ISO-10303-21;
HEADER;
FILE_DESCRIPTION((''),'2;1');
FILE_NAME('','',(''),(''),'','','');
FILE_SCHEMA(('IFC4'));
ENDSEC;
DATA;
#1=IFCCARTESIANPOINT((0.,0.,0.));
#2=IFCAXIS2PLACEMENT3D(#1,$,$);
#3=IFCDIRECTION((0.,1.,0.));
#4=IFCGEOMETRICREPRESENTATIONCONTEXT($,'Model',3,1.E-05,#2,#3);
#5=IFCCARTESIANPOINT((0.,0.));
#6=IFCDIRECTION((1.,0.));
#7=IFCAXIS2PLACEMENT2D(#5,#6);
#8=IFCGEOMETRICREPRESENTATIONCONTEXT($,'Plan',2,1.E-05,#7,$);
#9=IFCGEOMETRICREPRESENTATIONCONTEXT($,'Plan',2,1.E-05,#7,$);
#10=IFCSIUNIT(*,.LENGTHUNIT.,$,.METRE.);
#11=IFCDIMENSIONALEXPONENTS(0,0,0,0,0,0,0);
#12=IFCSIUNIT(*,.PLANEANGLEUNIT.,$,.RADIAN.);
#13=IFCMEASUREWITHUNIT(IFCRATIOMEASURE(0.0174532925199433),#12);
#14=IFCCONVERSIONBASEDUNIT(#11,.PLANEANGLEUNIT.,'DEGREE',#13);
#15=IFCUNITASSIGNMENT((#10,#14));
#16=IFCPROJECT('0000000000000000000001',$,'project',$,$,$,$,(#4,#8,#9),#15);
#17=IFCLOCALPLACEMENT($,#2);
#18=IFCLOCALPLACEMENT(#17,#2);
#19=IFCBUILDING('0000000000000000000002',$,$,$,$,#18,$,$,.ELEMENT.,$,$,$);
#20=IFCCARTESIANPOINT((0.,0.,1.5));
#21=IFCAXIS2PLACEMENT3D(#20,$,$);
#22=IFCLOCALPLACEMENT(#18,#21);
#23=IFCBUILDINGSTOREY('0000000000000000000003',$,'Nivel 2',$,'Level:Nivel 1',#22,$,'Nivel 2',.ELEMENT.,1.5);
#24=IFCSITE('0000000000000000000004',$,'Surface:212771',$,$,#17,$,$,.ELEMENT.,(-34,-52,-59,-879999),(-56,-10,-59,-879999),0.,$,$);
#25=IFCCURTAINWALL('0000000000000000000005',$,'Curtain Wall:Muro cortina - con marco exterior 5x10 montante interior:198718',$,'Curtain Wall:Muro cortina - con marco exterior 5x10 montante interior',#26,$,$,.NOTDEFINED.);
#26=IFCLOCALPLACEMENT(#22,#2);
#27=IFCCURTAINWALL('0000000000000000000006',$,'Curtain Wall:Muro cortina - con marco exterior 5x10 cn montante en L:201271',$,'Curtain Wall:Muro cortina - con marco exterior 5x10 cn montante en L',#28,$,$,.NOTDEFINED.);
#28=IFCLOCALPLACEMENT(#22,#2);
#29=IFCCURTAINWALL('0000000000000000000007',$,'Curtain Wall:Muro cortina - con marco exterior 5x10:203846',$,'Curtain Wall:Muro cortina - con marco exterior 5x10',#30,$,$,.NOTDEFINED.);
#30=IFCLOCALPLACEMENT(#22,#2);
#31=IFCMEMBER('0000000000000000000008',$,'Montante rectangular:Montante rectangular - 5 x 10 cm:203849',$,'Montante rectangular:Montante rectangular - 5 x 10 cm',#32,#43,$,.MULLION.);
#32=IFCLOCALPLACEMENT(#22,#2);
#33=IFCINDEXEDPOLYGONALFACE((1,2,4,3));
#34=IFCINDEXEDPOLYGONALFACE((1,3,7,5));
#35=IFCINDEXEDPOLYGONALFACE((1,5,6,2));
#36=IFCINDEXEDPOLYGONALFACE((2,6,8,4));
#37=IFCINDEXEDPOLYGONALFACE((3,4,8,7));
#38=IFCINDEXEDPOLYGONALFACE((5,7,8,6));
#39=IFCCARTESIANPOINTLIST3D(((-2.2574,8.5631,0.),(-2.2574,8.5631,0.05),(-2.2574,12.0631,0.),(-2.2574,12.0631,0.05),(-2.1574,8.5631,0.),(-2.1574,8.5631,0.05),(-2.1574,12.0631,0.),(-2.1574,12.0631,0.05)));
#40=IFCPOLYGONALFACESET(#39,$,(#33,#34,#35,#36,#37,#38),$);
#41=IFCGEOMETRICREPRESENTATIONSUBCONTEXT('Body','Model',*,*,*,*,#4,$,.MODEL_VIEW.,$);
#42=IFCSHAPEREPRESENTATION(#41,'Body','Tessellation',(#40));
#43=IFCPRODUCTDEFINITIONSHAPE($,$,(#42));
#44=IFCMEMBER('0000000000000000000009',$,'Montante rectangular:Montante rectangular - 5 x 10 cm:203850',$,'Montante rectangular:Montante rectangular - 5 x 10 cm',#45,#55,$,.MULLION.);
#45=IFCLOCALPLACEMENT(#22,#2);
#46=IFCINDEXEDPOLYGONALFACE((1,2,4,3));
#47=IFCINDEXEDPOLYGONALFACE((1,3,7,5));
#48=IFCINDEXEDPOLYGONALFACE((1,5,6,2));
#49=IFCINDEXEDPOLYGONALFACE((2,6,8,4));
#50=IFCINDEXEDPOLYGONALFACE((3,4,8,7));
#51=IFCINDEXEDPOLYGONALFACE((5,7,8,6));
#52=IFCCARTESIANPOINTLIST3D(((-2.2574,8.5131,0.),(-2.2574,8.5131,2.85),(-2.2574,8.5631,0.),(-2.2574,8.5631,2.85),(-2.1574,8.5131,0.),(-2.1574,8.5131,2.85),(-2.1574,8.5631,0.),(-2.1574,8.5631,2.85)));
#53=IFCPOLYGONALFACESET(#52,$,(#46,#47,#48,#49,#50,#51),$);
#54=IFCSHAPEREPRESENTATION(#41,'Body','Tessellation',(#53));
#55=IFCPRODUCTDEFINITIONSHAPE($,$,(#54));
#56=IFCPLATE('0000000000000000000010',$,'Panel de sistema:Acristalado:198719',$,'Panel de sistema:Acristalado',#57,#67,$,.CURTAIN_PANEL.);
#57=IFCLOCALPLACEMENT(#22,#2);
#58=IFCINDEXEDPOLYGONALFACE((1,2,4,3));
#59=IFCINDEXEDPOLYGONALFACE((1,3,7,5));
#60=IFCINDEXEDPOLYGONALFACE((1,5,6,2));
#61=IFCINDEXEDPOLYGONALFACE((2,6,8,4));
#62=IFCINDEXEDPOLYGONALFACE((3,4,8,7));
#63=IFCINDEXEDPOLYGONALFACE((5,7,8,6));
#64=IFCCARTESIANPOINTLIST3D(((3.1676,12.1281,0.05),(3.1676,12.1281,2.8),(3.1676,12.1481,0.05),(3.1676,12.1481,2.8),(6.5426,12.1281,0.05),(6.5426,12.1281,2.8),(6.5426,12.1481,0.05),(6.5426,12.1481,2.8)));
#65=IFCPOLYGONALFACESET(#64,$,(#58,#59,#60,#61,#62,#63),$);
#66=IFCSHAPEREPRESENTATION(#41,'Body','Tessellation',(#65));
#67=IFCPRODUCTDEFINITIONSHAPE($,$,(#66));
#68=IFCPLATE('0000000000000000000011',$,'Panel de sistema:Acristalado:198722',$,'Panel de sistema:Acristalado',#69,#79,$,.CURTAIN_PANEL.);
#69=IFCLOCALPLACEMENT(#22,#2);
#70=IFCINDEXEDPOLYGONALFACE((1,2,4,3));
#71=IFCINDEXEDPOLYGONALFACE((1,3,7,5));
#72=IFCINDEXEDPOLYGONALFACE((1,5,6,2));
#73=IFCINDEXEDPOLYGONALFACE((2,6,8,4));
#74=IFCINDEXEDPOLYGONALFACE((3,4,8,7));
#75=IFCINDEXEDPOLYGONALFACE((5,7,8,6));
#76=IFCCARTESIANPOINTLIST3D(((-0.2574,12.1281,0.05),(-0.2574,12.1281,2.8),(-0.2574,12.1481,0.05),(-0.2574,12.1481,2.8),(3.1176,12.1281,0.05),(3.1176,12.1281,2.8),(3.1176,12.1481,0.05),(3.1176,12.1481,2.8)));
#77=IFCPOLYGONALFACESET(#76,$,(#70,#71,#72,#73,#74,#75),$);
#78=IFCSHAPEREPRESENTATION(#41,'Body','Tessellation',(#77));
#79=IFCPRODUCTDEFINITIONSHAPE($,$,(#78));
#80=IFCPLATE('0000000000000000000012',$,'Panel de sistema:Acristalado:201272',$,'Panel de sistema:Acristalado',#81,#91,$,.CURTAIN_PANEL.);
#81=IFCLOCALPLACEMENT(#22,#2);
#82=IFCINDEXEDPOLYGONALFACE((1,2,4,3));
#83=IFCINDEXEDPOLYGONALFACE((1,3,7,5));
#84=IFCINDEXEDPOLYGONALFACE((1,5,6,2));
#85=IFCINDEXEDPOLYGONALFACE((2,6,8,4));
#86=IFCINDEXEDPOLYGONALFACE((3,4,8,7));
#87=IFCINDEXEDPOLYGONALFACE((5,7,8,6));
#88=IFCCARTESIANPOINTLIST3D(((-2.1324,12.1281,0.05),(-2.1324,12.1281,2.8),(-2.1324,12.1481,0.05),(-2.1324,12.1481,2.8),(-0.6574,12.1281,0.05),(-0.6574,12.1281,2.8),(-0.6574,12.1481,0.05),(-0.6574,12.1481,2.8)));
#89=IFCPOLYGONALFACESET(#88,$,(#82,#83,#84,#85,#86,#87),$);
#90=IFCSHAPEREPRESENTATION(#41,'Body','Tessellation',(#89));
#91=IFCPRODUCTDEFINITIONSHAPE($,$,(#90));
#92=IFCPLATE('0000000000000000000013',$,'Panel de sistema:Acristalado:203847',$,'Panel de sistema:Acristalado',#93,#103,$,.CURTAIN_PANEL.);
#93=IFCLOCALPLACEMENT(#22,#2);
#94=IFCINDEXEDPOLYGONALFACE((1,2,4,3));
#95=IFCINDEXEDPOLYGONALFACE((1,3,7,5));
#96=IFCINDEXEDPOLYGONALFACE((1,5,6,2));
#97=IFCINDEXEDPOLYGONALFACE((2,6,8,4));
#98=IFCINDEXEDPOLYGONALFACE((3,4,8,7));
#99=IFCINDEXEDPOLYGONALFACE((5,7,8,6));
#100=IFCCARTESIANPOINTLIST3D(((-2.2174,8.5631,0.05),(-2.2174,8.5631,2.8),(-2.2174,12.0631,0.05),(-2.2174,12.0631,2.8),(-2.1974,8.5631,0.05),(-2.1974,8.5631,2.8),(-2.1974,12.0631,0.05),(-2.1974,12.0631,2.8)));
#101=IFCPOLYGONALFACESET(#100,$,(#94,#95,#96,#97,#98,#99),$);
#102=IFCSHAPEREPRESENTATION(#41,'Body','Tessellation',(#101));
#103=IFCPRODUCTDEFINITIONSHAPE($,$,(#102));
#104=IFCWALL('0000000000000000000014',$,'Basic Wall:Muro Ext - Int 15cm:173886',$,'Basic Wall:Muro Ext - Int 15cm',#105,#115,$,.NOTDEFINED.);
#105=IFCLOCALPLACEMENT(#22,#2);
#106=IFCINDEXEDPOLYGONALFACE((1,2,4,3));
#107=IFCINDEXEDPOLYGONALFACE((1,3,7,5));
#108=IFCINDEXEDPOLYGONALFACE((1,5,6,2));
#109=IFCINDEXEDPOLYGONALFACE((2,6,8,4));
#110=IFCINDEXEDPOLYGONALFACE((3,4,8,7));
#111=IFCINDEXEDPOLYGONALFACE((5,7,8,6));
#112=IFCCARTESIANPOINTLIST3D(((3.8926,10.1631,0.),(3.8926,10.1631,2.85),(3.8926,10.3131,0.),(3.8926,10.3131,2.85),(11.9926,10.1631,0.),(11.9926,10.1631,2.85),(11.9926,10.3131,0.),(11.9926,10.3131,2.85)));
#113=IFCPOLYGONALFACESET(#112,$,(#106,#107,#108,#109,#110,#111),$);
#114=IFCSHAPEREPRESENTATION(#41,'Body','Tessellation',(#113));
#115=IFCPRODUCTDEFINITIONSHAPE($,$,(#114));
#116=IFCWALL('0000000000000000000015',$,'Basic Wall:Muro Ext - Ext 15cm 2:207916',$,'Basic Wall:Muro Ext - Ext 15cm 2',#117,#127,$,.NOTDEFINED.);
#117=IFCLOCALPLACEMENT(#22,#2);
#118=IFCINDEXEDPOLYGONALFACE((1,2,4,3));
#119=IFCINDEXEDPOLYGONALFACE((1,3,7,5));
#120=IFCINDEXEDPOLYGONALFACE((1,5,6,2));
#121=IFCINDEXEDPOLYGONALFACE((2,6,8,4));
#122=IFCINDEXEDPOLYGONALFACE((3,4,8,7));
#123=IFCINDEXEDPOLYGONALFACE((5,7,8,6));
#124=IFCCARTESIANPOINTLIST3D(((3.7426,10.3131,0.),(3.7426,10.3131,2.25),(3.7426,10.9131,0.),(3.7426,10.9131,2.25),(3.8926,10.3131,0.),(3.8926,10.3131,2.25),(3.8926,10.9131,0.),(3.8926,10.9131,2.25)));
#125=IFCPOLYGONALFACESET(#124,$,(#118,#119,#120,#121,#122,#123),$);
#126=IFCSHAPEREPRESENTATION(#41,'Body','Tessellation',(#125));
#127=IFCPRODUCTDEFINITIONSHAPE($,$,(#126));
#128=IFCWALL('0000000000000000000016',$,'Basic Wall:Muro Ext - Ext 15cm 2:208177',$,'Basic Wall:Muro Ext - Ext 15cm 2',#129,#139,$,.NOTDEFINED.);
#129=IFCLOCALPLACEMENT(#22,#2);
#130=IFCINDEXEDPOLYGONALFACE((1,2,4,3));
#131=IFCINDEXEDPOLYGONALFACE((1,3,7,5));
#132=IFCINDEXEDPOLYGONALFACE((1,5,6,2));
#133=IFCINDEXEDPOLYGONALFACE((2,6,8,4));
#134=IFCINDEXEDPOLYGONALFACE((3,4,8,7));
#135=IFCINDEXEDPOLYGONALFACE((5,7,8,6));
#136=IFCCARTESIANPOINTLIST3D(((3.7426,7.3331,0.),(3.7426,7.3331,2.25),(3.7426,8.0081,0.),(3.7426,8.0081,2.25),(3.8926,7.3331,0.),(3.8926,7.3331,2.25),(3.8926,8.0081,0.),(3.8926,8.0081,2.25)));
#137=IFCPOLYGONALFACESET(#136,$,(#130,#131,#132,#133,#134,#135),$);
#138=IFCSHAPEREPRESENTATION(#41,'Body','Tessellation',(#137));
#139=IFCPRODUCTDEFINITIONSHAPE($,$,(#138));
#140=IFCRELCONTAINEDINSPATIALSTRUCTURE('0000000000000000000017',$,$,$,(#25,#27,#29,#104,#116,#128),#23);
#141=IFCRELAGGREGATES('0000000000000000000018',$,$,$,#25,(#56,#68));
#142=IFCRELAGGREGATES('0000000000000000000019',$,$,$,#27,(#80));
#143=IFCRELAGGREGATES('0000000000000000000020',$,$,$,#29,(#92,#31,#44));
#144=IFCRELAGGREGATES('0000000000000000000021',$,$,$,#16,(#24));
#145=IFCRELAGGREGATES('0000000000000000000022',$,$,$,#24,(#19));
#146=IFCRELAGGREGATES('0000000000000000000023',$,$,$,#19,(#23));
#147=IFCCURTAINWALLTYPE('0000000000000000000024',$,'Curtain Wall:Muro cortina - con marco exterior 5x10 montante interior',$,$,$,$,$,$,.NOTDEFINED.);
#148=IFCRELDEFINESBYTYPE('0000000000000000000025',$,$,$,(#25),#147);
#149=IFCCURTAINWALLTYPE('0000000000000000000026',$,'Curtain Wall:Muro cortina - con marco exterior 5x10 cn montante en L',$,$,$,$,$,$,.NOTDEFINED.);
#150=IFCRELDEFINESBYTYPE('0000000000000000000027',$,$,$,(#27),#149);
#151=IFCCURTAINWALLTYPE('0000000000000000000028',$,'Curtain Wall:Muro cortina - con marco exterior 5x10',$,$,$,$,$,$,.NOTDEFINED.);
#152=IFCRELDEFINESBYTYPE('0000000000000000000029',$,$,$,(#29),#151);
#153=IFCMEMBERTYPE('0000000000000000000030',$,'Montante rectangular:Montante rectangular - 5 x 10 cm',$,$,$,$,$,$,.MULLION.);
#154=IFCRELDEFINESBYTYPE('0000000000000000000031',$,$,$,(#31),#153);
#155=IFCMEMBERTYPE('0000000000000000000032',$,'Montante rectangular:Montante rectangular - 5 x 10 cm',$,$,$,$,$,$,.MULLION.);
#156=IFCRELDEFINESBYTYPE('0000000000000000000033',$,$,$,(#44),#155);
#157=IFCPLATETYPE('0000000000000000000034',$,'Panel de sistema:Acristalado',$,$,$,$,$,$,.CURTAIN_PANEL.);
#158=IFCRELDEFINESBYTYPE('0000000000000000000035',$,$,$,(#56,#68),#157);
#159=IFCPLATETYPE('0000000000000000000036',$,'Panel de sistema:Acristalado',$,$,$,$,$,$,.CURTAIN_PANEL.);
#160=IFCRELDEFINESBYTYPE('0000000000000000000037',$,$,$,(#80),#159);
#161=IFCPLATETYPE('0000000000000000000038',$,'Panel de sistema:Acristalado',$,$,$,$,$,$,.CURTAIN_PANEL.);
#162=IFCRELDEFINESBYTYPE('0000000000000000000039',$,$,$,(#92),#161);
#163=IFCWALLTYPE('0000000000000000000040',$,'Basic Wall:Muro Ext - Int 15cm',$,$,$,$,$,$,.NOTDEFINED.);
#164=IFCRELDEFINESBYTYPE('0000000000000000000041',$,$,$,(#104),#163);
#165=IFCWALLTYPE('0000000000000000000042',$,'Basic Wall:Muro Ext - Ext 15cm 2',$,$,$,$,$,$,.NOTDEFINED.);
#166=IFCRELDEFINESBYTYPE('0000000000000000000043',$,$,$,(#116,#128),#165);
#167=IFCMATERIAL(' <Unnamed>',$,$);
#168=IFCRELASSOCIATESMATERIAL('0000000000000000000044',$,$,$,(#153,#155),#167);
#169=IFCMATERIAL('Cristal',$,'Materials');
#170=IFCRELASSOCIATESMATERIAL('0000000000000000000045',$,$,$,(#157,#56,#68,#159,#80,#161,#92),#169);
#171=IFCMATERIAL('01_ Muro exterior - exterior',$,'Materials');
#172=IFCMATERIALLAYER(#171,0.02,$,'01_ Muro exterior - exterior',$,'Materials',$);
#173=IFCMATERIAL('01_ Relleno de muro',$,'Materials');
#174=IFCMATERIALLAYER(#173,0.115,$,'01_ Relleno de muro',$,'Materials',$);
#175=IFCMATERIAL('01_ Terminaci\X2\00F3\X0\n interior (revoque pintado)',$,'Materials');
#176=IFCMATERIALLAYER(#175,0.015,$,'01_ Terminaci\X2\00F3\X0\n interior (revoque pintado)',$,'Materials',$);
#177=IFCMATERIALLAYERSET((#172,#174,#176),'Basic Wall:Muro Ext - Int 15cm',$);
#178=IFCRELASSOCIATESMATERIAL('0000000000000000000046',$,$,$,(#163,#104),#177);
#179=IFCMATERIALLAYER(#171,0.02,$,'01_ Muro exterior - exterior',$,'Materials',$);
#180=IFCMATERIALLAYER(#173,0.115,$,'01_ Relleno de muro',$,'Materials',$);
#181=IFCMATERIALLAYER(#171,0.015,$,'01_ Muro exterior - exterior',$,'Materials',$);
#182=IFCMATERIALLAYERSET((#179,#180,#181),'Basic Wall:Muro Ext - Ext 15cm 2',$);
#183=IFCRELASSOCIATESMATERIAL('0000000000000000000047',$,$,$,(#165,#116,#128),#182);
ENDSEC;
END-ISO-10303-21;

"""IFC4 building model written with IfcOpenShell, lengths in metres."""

from ifc_helpers import new_model, entity, si_unit, converted_unit, direction, frame, origin, origin_2d_with_axis, place, context, subcontext, project, spatial, indexed_curve, outline, extrude, shape, source, transform, mapped, material, layer, layer_set, type_object, type_shapes, element, aggregate, save


model = new_model("IFC4")

# Units and contexts
model_context = context("Model", 3, precision=1e-05, world=origin(), true_north=direction((0.0, 1.0, 0.0)))
plan_context_1 = context("Plan", 2, precision=1e-05, world=origin_2d_with_axis())
plan_context_2 = context("Plan", 2, precision=1e-05, world=origin_2d_with_axis())
body_context = subcontext(model_context, "Body", "Model", "MODEL_VIEW")
footprint_context = subcontext(model_context, "FootPrint", "Model", "MODEL_VIEW")
ifc_project = project(units=[si_unit("LENGTHUNIT", "METRE"), converted_unit("PLANEANGLEUNIT", "DEGREE", entity("IfcRatioMeasure", 0.0174532925199433), si_unit("PLANEANGLEUNIT", "RADIAN"), dimensions=[0, 0, 0, 0, 0, 0, 0])], contexts=[model_context, plan_context_1, plan_context_2])

# Site, building, storey
site_placement = place(None, origin())
site = spatial("IfcSite", under=ifc_project, at=site_placement, Name="Surface:212771", CompositionType="ELEMENT", RefLatitude=(-34, -52, -59, -879999), RefLongitude=(-56, -10, -59, -879999), RefElevation=0.0)
building_placement = place(site_placement, origin())
building = spatial("IfcBuilding", under=site, at=building_placement, CompositionType="ELEMENT")
storey_placement = place(building_placement, frame((0.0, 0.0, 1.5)))
storey = spatial("IfcBuildingStorey", under=building, at=storey_placement, Name="Nivel 2", ObjectType="Level:Nivel 1", LongName="Nivel 2", CompositionType="ELEMENT", Elevation=1.5)

# Curtain walls, members
curtain_wall_type_1 = type_object("IfcCurtainWallType", Name="Curtain Wall:Muro cortina - con marco exterior 5x10 montante interior", PredefinedType="NOTDEFINED")
curtain_wall_1_placement = place(storey_placement, frame((0.0, 0.0, -1.5)))
curtain_wall_1 = element("IfcCurtainWall", 1, at=curtain_wall_1_placement, inside=storey, type_object=curtain_wall_type_1, Name="Curtain Wall:Muro cortina - con marco exterior 5x10 montante interior:198718", ObjectType="Curtain Wall:Muro cortina - con marco exterior 5x10 montante interior", PredefinedType="NOTDEFINED")
ifc_material_1 = material(Name=" <Unnamed>")
curtain_wall_type_2 = type_object("IfcCurtainWallType", Name="Curtain Wall:Muro cortina - con marco exterior 5x10 cn montante en L", PredefinedType="NOTDEFINED")
curtain_wall_2_placement = place(storey_placement, frame((0.0, 0.0, -1.5)))
curtain_wall_2 = element("IfcCurtainWall", 2, at=curtain_wall_2_placement, inside=storey, type_object=curtain_wall_type_2, Name="Curtain Wall:Muro cortina - con marco exterior 5x10 cn montante en L:201271", ObjectType="Curtain Wall:Muro cortina - con marco exterior 5x10 cn montante en L", PredefinedType="NOTDEFINED")
curtain_wall_type_3 = type_object("IfcCurtainWallType", Name="Curtain Wall:Muro cortina - con marco exterior 5x10", PredefinedType="NOTDEFINED")
curtain_wall_3_placement = place(storey_placement, frame((0.0, 0.0, -1.5)))
curtain_wall_3 = element("IfcCurtainWall", 3, at=curtain_wall_3_placement, inside=storey, type_object=curtain_wall_type_3, Name="Curtain Wall:Muro cortina - con marco exterior 5x10:203846", ObjectType="Curtain Wall:Muro cortina - con marco exterior 5x10", PredefinedType="NOTDEFINED")
member_type_1 = type_object("IfcMemberType", Name="Montante rectangular:Montante rectangular - 5 x 10 cm", PredefinedType="MULLION", material=ifc_material_1)
shared_shape_1 = source(origin(), body_context, "Body", "SweptSolid", [
    extrude(outline(indexed_curve([(-0.05, -0.025), (0.05, -0.025), (0.05, 0.025), (-0.05, 0.025), (-0.05, -0.025)], self_intersect=False)), frame((-0.025, 0.0, -3.5), z_axis=(0.0, 0.0, 1.0), x_axis=(0.0, -1.0, 0.0)), (0.0, 0.0, 1.0), 3.5),
])
type_shapes(member_type_1, [shared_shape_1])
member_1_placement = place(storey_placement, frame((-2.2074, 12.0631, 0.0), z_axis=(0.0, 1.0, 0.0), x_axis=(0.0, 0.0, -1.0)))
member_1 = element("IfcMember", 4, at=member_1_placement, type_object=member_type_1, Name="Montante rectangular:Montante rectangular - 5 x 10 cm:203849", ObjectType="Montante rectangular:Montante rectangular - 5 x 10 cm", PredefinedType="MULLION", context=body_context, shape_type="MappedRepresentation", body=[
    mapped(shared_shape_1, transform((0.0, 0.0, 0.0), scale=1.0)),
])
member_type_2 = type_object("IfcMemberType", Name="Montante rectangular:Montante rectangular - 5 x 10 cm", PredefinedType="MULLION", material=ifc_material_1)
shared_shape_2 = source(origin(), body_context, "Body", "SweptSolid", [
    extrude(outline(indexed_curve([(-0.05, -0.025), (0.05, -0.025), (0.05, 0.025), (-0.05, 0.025), (-0.05, -0.025)], self_intersect=False)), frame((-0.025, 0.0, -2.85), z_axis=(0.0, 0.0, 1.0), x_axis=(0.0, -1.0, 0.0)), (0.0, 0.0, 1.0), 2.85),
])
type_shapes(member_type_2, [shared_shape_2])
member_2_placement = place(storey_placement, frame((-2.2074, 8.5131, 0.0), z_axis=(0.0, 0.0, -1.0), x_axis=(0.0, -1.0, 0.0)))
member_2 = element("IfcMember", 5, at=member_2_placement, type_object=member_type_2, Name="Montante rectangular:Montante rectangular - 5 x 10 cm:203850", ObjectType="Montante rectangular:Montante rectangular - 5 x 10 cm", PredefinedType="MULLION", context=body_context, shape_type="MappedRepresentation", body=[
    mapped(shared_shape_2, transform((0.0, 0.0, 0.0), scale=1.0)),
])

# Plates
ifc_material_2 = material(Name="Cristal", Category="Materials")
plate_type_1 = type_object("IfcPlateType", Name="Panel de sistema:Acristalado", PredefinedType="CURTAIN_PANEL", material=ifc_material_2)
shared_shape_3 = source(origin(), body_context, "Body", "SweptSolid", [
    extrude(outline(indexed_curve([(-0.01, -1.6875), (0.01, -1.6875), (0.01, 1.6875), (-0.01, 1.6875), (-0.01, -1.6875)], self_intersect=False)), frame((0.0, 0.0, 0.0), z_axis=(0.0, 0.0, 1.0), x_axis=(0.0, 1.0, 0.0)), (0.0, 0.0, 1.0), 2.75),
])
shared_shape_4 = source(origin(), footprint_context, "FootPrint", "Curve2D", [
    entity("IfcIndexedPolyCurve", entity("IfcCartesianPointList2D", [[1.6875, -0.01], [1.6875, 0.01], [-1.6875, 0.01], [-1.6875, -0.01], [1.6875, -0.01]]), None, False),
])
type_shapes(plate_type_1, [shared_shape_3, shared_shape_4])
plate_1_placement = place(curtain_wall_1_placement, frame((4.8551, 12.1381, 1.55), z_axis=(0.0, 0.0, 1.0), x_axis=(-1.0, 0.0, 0.0)))
plate_1 = element("IfcPlate", 6, at=plate_1_placement, type_object=plate_type_1, material=ifc_material_2, Name="Panel de sistema:Acristalado:198719", ObjectType="Panel de sistema:Acristalado", PredefinedType="CURTAIN_PANEL", shapes=[
    shape(body_context, "Body", "MappedRepresentation", [mapped(shared_shape_3, transform((0.0, 0.0, 0.0), scale=1.0))]),
    shape(body_context, "Body", "MappedRepresentation", [mapped(shared_shape_4, transform((0.0, 0.0, 0.0), scale=1.0))]),
])
plate_2_placement = place(curtain_wall_1_placement, frame((1.4301, 12.1381, 1.55), z_axis=(0.0, 0.0, 1.0), x_axis=(-1.0, 0.0, 0.0)))
plate_2 = element("IfcPlate", 7, at=plate_2_placement, type_object=plate_type_1, material=ifc_material_2, Name="Panel de sistema:Acristalado:198722", ObjectType="Panel de sistema:Acristalado", PredefinedType="CURTAIN_PANEL", shapes=[
    shape(body_context, "Body", "MappedRepresentation", [mapped(shared_shape_3, transform((0.0, 0.0, 0.0), scale=1.0))]),
    shape(body_context, "Body", "MappedRepresentation", [mapped(shared_shape_4, transform((0.0, 0.0, 0.0), scale=1.0))]),
])
aggregate(curtain_wall_1, [plate_1, plate_2])
plate_type_2 = type_object("IfcPlateType", Name="Panel de sistema:Acristalado", PredefinedType="CURTAIN_PANEL", material=ifc_material_2)
shared_shape_5 = source(origin(), body_context, "Body", "SweptSolid", [
    extrude(outline(indexed_curve([(-0.01, -0.7375), (0.01, -0.7375), (0.01, 0.7375), (-0.01, 0.7375), (-0.01, -0.7375)], self_intersect=False)), frame((0.0, 0.0, 0.0), z_axis=(0.0, 0.0, 1.0), x_axis=(0.0, 1.0, 0.0)), (0.0, 0.0, 1.0), 2.75),
])
shared_shape_6 = source(origin(), footprint_context, "FootPrint", "Curve2D", [
    entity("IfcIndexedPolyCurve", entity("IfcCartesianPointList2D", [[0.7375, -0.01], [0.7375, 0.01], [-0.7375, 0.01], [-0.7375, -0.01], [0.7375, -0.01]]), None, False),
])
type_shapes(plate_type_2, [shared_shape_5, shared_shape_6])
plate_3_placement = place(curtain_wall_2_placement, frame((-1.3949, 12.1381, 1.55), z_axis=(0.0, 0.0, 1.0), x_axis=(-1.0, 0.0, 0.0)))
plate_3 = element("IfcPlate", 8, at=plate_3_placement, type_object=plate_type_2, material=ifc_material_2, Name="Panel de sistema:Acristalado:201272", ObjectType="Panel de sistema:Acristalado", PredefinedType="CURTAIN_PANEL", shapes=[
    shape(body_context, "Body", "MappedRepresentation", [mapped(shared_shape_5, transform((0.0, 0.0, 0.0), scale=1.0))]),
    shape(body_context, "Body", "MappedRepresentation", [mapped(shared_shape_6, transform((0.0, 0.0, 0.0), scale=1.0))]),
])
aggregate(curtain_wall_2, [plate_3])
plate_type_3 = type_object("IfcPlateType", Name="Panel de sistema:Acristalado", PredefinedType="CURTAIN_PANEL", material=ifc_material_2)
shared_shape_7 = source(origin(), body_context, "Body", "SweptSolid", [
    extrude(outline(indexed_curve([(-0.01, -1.75), (0.01, -1.75), (0.01, 1.75), (-0.01, 1.75), (-0.01, -1.75)], self_intersect=False)), frame((0.0, 0.0, 0.0), z_axis=(0.0, 0.0, 1.0), x_axis=(0.0, 1.0, 0.0)), (0.0, 0.0, 1.0), 2.75),
])
shared_shape_8 = source(origin(), footprint_context, "FootPrint", "Curve2D", [
    entity("IfcIndexedPolyCurve", entity("IfcCartesianPointList2D", [[1.75, -0.01], [1.75, 0.01], [-1.75, 0.01], [-1.75, -0.01], [1.75, -0.01]]), None, False),
])
type_shapes(plate_type_3, [shared_shape_7, shared_shape_8])
plate_4_placement = place(curtain_wall_3_placement, frame((-2.2074, 10.3131, 1.55), z_axis=(0.0, 0.0, 1.0), x_axis=(0.0, -1.0, 0.0)))
plate_4 = element("IfcPlate", 9, at=plate_4_placement, type_object=plate_type_3, material=ifc_material_2, Name="Panel de sistema:Acristalado:203847", ObjectType="Panel de sistema:Acristalado", PredefinedType="CURTAIN_PANEL", shapes=[
    shape(body_context, "Body", "MappedRepresentation", [mapped(shared_shape_7, transform((0.0, 0.0, 0.0), scale=1.0))]),
    shape(body_context, "Body", "MappedRepresentation", [mapped(shared_shape_8, transform((0.0, 0.0, 0.0), scale=1.0))]),
])
aggregate(curtain_wall_3, [plate_4, member_1, member_2])

# Walls
ifc_material_3 = material(Name="01_ Muro exterior - exterior", Category="Materials")
ifc_layer_1 = layer(ifc_material_3, 0.02, Name="01_ Muro exterior - exterior", Category="Materials")
ifc_material_4 = material(Name="01_ Relleno de muro", Category="Materials")
ifc_layer_2 = layer(ifc_material_4, 0.115, Name="01_ Relleno de muro", Category="Materials")
ifc_material_5 = material(Name="01_ Terminación interior (revoque pintado)", Category="Materials")
ifc_layer_3 = layer(ifc_material_5, 0.015, Name="01_ Terminación interior (revoque pintado)", Category="Materials")
ifc_layer_set_1 = layer_set([ifc_layer_1, ifc_layer_2, ifc_layer_3], Name="Basic Wall:Muro Ext - Int 15cm")
wall_type_1 = type_object("IfcWallType", Name="Basic Wall:Muro Ext - Int 15cm", PredefinedType="NOTDEFINED", material=ifc_layer_set_1)
wall_1_placement = place(storey_placement, frame((3.8926, 10.2381, 0.0)))
element("IfcWall", 10, at=wall_1_placement, inside=storey, type_object=wall_type_1, material=ifc_layer_set_1, Name="Basic Wall:Muro Ext - Int 15cm:173886", ObjectType="Basic Wall:Muro Ext - Int 15cm", PredefinedType="NOTDEFINED", context=body_context, shape_type="SweptSolid", body=[
    extrude(outline(indexed_curve([(8.1, 0.075), (0.0, 0.075), (0.0, -0.075), (8.1, -0.075), (8.1, 0.075)], self_intersect=False)), origin(), (0.0, 0.0, 1.0), 2.85),
])
ifc_layer_4 = layer(ifc_material_3, 0.02, Name="01_ Muro exterior - exterior", Category="Materials")
ifc_layer_5 = layer(ifc_material_4, 0.115, Name="01_ Relleno de muro", Category="Materials")
ifc_layer_6 = layer(ifc_material_3, 0.015, Name="01_ Muro exterior - exterior", Category="Materials")
ifc_layer_set_2 = layer_set([ifc_layer_4, ifc_layer_5, ifc_layer_6], Name="Basic Wall:Muro Ext - Ext 15cm 2")
wall_type_2 = type_object("IfcWallType", Name="Basic Wall:Muro Ext - Ext 15cm 2", PredefinedType="NOTDEFINED", material=ifc_layer_set_2)
wall_2_placement = place(storey_placement, frame((3.8176, 10.3131, 0.0), z_axis=(0.0, 0.0, 1.0), x_axis=(0.0, 1.0, 0.0)))
element("IfcWall", 11, at=wall_2_placement, inside=storey, type_object=wall_type_2, material=ifc_layer_set_2, Name="Basic Wall:Muro Ext - Ext 15cm 2:207916", ObjectType="Basic Wall:Muro Ext - Ext 15cm 2", PredefinedType="NOTDEFINED", context=body_context, shape_type="SweptSolid", body=[
    extrude(outline(indexed_curve([(0.6, 0.075), (0.0, 0.075), (0.0, -0.075), (0.6, -0.075), (0.6, 0.075)], self_intersect=False)), origin(), (0.0, 0.0, 1.0), 2.25),
])
wall_3_placement = place(storey_placement, frame((3.8176, 8.0081, 0.0), z_axis=(0.0, 0.0, 1.0), x_axis=(0.0, -1.0, 0.0)))
element("IfcWall", 12, at=wall_3_placement, inside=storey, type_object=wall_type_2, material=ifc_layer_set_2, Name="Basic Wall:Muro Ext - Ext 15cm 2:208177", ObjectType="Basic Wall:Muro Ext - Ext 15cm 2", PredefinedType="NOTDEFINED", context=body_context, shape_type="SweptSolid", body=[
    extrude(outline(indexed_curve([(0.675, 0.075), (0.0, 0.075), (0.0, -0.075), (0.675, -0.075), (0.675, 0.075)], self_intersect=False)), origin(), (0.0, 0.0, 1.0), 2.25),
])

save(model, "model.ifc")
